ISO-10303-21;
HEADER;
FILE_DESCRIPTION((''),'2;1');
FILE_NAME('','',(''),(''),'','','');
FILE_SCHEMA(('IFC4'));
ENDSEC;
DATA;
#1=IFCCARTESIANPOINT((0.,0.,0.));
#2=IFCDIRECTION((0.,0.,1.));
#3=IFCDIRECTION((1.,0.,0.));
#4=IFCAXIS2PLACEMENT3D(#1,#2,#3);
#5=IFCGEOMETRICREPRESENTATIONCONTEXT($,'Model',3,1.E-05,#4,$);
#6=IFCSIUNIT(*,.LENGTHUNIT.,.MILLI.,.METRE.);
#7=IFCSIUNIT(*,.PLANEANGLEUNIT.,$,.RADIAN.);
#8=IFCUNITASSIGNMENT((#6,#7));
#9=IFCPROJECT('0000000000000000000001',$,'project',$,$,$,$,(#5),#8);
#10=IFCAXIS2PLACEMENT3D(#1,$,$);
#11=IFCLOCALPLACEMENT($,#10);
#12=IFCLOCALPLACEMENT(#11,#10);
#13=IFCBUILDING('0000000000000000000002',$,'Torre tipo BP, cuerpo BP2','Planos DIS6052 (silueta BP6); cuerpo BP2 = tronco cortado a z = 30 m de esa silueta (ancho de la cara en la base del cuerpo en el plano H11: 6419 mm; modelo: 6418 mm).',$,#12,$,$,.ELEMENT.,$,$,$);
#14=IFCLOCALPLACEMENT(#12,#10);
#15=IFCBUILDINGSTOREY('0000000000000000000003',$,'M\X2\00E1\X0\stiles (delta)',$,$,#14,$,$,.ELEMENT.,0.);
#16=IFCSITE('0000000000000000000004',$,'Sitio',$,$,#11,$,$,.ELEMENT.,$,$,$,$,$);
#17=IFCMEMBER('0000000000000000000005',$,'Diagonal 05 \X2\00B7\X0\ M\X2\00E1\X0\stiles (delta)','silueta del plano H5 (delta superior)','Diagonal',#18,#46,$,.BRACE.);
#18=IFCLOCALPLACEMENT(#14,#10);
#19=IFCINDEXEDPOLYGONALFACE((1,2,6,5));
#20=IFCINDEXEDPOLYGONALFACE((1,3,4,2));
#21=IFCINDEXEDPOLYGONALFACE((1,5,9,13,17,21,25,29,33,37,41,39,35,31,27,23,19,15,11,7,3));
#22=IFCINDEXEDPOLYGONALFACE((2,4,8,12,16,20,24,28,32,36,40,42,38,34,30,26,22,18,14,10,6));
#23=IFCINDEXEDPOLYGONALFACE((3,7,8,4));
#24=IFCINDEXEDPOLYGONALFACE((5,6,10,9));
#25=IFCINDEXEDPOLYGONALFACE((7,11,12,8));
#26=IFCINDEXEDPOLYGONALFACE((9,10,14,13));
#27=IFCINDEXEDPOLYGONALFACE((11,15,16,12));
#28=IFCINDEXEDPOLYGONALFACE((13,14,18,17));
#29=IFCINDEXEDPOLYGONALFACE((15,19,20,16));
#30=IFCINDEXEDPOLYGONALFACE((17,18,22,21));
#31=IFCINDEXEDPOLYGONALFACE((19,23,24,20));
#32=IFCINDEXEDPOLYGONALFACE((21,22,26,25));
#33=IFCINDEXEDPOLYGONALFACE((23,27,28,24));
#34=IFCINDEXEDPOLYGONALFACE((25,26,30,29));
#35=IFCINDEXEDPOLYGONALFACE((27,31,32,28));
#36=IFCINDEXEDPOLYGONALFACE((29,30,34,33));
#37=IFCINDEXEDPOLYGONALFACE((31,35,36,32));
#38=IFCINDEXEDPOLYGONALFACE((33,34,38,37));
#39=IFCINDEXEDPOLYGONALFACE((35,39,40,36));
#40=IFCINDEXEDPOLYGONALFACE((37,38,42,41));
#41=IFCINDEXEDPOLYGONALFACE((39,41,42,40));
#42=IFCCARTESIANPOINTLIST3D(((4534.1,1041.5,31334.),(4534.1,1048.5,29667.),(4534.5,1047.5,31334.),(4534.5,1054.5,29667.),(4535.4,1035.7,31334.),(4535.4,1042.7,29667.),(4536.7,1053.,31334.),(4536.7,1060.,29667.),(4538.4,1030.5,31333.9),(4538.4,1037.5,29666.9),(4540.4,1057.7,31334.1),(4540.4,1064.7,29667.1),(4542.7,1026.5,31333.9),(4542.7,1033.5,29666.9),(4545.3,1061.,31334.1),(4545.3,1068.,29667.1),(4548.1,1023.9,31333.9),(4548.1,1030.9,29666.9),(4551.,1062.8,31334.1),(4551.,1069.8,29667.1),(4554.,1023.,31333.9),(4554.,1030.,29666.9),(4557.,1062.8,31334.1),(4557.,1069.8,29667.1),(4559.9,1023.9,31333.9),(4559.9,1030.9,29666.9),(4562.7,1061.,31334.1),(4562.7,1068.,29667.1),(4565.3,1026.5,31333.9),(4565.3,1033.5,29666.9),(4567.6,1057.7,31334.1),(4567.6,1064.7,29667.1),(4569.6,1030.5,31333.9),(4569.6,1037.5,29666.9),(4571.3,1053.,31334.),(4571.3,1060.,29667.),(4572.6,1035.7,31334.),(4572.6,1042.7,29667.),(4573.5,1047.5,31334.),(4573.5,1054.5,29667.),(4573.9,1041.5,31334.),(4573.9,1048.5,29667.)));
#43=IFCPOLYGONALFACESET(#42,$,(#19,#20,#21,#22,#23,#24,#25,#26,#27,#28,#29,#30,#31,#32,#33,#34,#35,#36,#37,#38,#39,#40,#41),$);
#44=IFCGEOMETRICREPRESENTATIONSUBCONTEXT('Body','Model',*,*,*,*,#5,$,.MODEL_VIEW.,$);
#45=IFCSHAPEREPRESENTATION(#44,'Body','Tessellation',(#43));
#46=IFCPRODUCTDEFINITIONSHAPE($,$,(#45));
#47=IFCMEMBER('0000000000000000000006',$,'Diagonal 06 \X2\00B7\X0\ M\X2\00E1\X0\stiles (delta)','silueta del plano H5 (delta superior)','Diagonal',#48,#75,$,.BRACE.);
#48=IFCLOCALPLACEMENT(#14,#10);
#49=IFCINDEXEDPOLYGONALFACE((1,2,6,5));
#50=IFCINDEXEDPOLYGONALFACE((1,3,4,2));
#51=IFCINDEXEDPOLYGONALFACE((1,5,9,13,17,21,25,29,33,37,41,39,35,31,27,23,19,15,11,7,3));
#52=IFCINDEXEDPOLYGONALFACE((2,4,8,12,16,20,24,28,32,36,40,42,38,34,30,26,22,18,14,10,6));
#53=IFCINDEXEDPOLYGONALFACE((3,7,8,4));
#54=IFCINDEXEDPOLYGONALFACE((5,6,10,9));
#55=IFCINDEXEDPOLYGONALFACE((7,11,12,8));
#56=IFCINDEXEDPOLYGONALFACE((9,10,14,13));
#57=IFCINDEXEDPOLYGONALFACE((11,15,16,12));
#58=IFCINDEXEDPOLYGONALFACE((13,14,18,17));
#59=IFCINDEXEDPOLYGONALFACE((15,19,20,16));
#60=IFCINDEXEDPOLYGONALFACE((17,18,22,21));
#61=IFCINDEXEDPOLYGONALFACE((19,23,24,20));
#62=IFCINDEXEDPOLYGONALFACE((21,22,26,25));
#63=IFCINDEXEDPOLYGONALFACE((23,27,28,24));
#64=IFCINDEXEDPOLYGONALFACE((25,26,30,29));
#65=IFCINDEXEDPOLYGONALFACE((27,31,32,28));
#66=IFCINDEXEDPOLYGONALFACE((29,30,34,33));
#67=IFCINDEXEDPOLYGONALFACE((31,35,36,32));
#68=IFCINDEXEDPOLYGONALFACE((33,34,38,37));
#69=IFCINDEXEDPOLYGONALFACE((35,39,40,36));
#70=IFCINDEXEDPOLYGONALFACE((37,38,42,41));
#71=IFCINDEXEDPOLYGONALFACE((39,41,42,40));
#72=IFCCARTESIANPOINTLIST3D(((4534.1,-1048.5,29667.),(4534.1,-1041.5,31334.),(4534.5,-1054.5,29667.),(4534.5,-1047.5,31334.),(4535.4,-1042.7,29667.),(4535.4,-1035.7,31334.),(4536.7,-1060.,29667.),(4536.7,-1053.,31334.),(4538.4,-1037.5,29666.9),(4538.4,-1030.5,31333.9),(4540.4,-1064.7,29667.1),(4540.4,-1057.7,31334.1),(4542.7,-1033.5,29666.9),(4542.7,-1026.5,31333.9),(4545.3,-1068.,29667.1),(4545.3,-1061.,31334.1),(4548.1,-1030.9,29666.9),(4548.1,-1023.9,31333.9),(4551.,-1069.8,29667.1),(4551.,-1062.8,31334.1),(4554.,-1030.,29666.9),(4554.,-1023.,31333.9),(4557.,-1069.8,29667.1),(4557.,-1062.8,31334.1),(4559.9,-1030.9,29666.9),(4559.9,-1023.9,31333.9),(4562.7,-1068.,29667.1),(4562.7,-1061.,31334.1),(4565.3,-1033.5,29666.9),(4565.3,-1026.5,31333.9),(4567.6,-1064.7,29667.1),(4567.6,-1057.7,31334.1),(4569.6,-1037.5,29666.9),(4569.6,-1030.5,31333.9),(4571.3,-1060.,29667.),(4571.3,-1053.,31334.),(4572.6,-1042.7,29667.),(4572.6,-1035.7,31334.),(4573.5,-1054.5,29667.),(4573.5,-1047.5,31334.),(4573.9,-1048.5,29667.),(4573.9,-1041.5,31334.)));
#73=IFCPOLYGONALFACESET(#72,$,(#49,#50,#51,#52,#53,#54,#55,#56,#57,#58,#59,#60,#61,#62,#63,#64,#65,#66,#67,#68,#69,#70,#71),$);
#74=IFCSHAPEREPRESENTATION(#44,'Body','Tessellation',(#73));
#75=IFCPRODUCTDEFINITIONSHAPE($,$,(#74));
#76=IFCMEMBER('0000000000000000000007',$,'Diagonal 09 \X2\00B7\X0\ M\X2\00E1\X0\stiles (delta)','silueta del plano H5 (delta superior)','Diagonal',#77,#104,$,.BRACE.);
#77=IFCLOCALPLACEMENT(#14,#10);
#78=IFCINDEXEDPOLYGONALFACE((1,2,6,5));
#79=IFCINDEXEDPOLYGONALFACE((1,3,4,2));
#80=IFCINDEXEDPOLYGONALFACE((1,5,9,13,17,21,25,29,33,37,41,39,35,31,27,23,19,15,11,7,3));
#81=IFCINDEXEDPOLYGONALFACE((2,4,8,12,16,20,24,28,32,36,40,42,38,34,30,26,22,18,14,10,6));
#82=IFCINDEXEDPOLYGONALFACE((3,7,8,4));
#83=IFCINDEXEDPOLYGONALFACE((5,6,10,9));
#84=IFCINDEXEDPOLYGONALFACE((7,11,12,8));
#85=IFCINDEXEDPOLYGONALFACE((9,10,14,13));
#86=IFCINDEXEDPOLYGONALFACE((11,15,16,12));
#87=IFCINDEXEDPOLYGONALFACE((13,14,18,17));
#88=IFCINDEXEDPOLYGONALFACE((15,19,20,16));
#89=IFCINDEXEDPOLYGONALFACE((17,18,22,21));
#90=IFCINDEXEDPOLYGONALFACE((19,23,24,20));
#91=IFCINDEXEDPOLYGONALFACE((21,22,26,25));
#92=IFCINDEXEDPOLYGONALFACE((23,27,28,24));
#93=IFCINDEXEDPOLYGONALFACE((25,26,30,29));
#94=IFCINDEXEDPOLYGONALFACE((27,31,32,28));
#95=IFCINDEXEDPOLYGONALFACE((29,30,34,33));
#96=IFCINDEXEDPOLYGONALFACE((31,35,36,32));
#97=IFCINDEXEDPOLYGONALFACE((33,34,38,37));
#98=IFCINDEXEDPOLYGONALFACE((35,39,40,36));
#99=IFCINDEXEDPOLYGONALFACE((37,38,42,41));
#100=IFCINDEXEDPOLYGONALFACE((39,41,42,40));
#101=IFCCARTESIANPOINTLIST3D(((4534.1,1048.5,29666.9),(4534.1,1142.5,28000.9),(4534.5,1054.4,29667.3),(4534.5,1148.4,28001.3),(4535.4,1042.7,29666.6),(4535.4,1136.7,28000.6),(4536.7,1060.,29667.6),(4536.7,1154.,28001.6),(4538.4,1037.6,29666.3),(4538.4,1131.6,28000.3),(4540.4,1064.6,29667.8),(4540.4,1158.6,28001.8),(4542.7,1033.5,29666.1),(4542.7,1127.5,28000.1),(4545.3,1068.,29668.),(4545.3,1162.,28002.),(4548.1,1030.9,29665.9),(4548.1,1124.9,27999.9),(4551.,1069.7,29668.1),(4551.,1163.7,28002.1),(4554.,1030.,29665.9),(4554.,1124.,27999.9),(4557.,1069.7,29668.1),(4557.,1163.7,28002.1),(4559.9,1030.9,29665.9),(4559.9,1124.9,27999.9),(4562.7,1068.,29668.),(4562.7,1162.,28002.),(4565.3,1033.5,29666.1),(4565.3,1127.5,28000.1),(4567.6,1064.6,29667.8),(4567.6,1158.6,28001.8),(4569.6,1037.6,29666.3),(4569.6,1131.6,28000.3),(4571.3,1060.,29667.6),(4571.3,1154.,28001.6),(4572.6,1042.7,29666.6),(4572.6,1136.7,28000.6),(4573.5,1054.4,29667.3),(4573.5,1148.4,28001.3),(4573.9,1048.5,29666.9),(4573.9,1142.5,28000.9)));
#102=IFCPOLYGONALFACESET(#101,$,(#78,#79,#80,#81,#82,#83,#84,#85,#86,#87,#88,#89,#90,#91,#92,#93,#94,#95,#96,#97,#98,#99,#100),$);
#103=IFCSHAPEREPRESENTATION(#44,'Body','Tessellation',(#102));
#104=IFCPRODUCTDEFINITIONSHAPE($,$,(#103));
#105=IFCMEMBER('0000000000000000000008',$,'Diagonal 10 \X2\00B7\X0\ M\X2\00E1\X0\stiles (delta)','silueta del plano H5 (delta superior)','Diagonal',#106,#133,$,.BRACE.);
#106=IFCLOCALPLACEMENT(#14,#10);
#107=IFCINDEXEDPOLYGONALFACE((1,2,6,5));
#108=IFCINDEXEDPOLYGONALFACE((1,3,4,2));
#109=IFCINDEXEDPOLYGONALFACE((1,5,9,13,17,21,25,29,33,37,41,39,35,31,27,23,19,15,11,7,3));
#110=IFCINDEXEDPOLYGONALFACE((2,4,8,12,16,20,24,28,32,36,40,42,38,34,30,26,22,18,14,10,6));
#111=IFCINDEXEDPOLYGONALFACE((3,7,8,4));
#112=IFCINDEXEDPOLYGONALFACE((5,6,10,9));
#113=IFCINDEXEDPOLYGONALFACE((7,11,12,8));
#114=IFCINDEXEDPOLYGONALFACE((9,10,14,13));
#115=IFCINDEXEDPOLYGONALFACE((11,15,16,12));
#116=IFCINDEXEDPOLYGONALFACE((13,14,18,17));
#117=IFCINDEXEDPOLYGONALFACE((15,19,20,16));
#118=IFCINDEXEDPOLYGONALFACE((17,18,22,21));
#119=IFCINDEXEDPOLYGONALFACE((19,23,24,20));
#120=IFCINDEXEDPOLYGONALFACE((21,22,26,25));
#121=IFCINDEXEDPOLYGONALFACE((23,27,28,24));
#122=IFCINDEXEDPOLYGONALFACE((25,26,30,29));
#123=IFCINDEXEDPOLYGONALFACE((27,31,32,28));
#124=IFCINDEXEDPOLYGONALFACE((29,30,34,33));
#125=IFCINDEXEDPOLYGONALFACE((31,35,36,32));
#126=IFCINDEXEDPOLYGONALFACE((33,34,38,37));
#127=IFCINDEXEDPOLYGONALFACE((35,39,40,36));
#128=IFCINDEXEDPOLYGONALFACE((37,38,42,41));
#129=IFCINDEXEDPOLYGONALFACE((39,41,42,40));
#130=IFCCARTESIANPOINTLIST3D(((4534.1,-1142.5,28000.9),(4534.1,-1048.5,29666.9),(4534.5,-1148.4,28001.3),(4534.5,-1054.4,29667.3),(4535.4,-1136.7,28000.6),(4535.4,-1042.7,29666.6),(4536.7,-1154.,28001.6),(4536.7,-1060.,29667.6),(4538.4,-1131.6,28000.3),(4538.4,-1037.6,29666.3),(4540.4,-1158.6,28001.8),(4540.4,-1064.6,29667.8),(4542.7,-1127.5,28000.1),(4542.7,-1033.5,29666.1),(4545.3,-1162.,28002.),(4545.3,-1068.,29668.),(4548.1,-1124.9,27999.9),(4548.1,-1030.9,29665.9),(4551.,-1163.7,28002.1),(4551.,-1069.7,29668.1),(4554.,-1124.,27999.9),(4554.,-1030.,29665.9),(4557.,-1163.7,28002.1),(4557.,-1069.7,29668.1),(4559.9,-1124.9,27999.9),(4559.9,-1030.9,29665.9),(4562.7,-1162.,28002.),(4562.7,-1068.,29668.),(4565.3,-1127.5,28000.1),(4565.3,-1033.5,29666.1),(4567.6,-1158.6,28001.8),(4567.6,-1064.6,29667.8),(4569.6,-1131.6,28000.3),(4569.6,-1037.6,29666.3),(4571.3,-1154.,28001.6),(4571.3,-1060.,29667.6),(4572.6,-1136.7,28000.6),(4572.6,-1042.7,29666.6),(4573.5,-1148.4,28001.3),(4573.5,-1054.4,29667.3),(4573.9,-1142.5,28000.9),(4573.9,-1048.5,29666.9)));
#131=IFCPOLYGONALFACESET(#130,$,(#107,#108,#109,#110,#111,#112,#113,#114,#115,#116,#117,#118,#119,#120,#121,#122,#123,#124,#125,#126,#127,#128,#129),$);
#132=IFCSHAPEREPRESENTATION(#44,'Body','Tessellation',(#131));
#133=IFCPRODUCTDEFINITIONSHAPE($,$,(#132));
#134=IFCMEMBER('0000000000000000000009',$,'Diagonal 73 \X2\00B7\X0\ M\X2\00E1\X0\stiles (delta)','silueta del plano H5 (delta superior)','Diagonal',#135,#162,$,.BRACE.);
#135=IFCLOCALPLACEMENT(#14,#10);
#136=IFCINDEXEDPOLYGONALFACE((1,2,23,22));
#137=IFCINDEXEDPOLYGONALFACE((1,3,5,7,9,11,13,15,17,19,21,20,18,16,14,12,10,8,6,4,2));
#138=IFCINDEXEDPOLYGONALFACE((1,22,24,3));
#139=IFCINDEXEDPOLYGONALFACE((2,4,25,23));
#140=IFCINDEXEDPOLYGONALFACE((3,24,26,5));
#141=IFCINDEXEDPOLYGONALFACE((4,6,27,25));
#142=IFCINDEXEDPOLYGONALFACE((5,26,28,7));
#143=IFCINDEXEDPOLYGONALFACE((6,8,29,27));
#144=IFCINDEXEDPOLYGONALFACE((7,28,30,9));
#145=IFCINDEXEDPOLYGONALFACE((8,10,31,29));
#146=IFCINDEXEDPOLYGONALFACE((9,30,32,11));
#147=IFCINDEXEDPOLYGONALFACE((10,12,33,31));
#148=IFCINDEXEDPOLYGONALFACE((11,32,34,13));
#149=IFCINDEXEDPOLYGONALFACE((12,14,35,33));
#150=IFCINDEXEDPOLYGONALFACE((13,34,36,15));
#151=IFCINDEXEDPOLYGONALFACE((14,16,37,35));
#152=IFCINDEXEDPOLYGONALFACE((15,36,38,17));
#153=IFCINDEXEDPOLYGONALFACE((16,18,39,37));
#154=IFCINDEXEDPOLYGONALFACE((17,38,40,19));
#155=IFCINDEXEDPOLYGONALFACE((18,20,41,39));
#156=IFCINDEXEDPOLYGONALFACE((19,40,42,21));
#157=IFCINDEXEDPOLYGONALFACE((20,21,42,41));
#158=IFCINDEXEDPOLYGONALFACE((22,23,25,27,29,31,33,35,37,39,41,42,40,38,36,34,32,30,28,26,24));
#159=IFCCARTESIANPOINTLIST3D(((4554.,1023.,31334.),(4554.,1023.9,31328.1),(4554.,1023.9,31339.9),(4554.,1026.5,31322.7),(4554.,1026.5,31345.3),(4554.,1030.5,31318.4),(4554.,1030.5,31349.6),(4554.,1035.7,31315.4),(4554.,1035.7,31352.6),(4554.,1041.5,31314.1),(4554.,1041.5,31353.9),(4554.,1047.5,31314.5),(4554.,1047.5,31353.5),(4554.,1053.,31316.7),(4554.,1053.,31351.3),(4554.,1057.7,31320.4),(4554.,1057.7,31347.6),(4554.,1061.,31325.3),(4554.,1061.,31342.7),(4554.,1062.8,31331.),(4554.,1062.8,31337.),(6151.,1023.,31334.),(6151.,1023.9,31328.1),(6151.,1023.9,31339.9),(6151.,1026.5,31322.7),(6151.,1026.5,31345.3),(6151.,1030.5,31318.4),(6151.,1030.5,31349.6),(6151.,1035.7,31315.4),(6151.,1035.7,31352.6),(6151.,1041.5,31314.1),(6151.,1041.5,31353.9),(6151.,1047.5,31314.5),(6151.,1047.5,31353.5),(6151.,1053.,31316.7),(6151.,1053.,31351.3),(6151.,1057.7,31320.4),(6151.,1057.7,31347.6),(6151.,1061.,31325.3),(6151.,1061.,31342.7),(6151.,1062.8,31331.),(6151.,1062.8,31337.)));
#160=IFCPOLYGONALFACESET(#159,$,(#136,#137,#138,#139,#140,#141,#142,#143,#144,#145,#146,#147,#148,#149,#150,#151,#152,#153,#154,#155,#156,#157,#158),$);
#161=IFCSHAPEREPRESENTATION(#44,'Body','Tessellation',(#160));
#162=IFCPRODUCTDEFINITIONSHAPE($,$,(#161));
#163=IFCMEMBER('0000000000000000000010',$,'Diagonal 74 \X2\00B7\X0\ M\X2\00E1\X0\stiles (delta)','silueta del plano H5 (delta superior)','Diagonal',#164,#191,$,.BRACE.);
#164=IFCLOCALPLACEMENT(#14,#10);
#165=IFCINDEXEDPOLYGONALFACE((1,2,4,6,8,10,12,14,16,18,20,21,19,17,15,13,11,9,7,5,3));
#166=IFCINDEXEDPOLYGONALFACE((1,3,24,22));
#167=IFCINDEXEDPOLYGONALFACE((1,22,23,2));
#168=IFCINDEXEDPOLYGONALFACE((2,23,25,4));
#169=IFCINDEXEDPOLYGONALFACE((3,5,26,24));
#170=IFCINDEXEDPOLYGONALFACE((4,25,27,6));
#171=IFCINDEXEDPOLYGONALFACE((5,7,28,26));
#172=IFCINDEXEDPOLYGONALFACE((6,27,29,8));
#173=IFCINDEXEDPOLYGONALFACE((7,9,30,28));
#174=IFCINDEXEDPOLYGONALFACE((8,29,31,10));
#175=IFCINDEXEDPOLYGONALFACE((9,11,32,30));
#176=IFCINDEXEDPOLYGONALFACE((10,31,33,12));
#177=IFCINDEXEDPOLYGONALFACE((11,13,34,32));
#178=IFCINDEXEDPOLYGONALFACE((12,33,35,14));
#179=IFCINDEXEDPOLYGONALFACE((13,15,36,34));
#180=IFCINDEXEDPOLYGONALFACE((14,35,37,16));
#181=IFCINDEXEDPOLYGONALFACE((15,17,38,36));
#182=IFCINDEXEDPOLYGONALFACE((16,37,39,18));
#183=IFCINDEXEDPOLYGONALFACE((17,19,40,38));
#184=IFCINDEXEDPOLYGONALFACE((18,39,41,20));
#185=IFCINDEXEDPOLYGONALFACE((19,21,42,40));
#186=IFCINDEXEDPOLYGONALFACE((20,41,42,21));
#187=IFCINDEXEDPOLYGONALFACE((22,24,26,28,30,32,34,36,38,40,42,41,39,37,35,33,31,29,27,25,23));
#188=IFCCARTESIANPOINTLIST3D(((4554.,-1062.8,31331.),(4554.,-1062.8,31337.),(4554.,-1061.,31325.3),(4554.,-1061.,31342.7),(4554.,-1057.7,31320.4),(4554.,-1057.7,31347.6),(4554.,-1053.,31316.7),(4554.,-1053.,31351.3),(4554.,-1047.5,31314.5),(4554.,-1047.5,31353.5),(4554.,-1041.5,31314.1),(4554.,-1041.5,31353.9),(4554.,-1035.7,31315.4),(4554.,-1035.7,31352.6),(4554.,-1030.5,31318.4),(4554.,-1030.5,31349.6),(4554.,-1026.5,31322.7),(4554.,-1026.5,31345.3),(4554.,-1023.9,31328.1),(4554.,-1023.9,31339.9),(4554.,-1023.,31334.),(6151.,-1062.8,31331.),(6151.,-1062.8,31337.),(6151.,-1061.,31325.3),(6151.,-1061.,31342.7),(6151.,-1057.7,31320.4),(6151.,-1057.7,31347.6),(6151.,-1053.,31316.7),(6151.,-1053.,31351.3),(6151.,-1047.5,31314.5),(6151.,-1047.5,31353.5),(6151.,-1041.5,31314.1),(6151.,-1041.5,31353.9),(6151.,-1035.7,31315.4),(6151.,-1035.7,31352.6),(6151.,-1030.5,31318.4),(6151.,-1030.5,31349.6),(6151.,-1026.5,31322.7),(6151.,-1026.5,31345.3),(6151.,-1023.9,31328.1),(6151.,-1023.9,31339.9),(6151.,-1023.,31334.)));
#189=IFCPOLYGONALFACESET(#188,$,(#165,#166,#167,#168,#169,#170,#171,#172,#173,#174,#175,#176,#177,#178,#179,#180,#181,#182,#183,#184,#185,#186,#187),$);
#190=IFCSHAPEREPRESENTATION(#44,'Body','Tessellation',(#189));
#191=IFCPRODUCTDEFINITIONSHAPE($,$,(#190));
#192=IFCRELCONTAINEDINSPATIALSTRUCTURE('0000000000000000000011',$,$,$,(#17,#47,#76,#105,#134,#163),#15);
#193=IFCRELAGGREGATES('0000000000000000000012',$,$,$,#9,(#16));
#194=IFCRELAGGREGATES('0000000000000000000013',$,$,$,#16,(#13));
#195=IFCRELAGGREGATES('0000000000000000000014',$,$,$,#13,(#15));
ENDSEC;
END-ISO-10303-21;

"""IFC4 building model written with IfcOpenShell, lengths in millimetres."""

from ifc_helpers import new_model, si_unit, frame, origin, origin_with_axes, place, context, subcontext, project, spatial, circle, extrude, element, save


model = new_model("IFC4")

# Units and contexts
model_context = context("Model", 3, precision=1e-05, world=origin_with_axes())
body_context = subcontext(model_context, "Body", "Model", "MODEL_VIEW")
ifc_project = project(units=[si_unit("LENGTHUNIT", "METRE", prefix="MILLI"), si_unit("PLANEANGLEUNIT", "RADIAN")], contexts=[model_context])

# Site, building, storey
site_placement = place(None, origin())
site = spatial("IfcSite", under=ifc_project, at=site_placement, Name="Sitio", CompositionType="ELEMENT")
building_placement = place(site_placement, origin())
building = spatial("IfcBuilding", under=site, at=building_placement, Name="Torre tipo BP, cuerpo BP2", Description="Planos DIS6052 (silueta BP6); cuerpo BP2 = tronco cortado a z = 30 m de esa silueta (ancho de la cara en la base del cuerpo en el plano H11: 6419 mm; modelo: 6418 mm).", CompositionType="ELEMENT")
storey_placement = place(building_placement, origin())
storey = spatial("IfcBuildingStorey", under=building, at=storey_placement, Name="Mástiles (delta)", CompositionType="ELEMENT", Elevation=0.0)

# Members
for number, where, z_axis, x_axis, name in (
    (1, (4554.0, 1043.0, 31334.0), (0.0, 0.004199, -0.999991), (0.0, -0.999991, -0.004199), "Diagonal 05 · Mástiles (delta)"),
    (2, (4554.0, -1043.0, 31334.0), (0.0, -0.004199, -0.999991), (0.0, 0.999991, -0.004199), "Diagonal 06 · Mástiles (delta)"),
):
    element("IfcMember", number, at=place(storey_placement, frame(where, z_axis=z_axis, x_axis=x_axis)), inside=storey, Name=name, Description="silueta del plano H5 (delta superior)", ObjectType="Diagonal", PredefinedType="BRACE", context=body_context, shape_type="SweptSolid", body=[
        extrude(circle(Radius=20.0), None, (0.0, 0.0, 1.0), 1667.0),
    ])
for number, where, z_axis, x_axis, name in (
    (3, (4554.0, 1050.0, 29667.0), (0.0, 0.056333, -0.998412), (0.0, -0.998412, -0.056333), "Diagonal 09 · Mástiles (delta)"),
    (4, (4554.0, -1050.0, 29667.0), (0.0, -0.056333, -0.998412), (0.0, 0.998412, -0.056333), "Diagonal 10 · Mástiles (delta)"),
):
    element("IfcMember", number, at=place(storey_placement, frame(where, z_axis=z_axis, x_axis=x_axis)), inside=storey, Name=name, Description="silueta del plano H5 (delta superior)", ObjectType="Diagonal", PredefinedType="BRACE", context=body_context, shape_type="SweptSolid", body=[
        extrude(circle(Radius=20.0), None, (0.0, 0.0, 1.0), 1668.6),
    ])
for number, where, z_axis, x_axis, name in (
    (5, (4554.0, 1043.0, 31334.0), (1.0, 0.0, 0.0), (0.0, -1.0, 0.0), "Diagonal 73 · Mástiles (delta)"),
    (6, (4554.0, -1043.0, 31334.0), (1.0, 0.0, 0.0), (0.0, 1.0, 0.0), "Diagonal 74 · Mástiles (delta)"),
):
    element("IfcMember", number, at=place(storey_placement, frame(where, z_axis=z_axis, x_axis=x_axis)), inside=storey, Name=name, Description="silueta del plano H5 (delta superior)", ObjectType="Diagonal", PredefinedType="BRACE", context=body_context, shape_type="SweptSolid", body=[
        extrude(circle(Radius=20.0), None, (0.0, 0.0, 1.0), 1597.0),
    ])

save(model, "model.ifc")
